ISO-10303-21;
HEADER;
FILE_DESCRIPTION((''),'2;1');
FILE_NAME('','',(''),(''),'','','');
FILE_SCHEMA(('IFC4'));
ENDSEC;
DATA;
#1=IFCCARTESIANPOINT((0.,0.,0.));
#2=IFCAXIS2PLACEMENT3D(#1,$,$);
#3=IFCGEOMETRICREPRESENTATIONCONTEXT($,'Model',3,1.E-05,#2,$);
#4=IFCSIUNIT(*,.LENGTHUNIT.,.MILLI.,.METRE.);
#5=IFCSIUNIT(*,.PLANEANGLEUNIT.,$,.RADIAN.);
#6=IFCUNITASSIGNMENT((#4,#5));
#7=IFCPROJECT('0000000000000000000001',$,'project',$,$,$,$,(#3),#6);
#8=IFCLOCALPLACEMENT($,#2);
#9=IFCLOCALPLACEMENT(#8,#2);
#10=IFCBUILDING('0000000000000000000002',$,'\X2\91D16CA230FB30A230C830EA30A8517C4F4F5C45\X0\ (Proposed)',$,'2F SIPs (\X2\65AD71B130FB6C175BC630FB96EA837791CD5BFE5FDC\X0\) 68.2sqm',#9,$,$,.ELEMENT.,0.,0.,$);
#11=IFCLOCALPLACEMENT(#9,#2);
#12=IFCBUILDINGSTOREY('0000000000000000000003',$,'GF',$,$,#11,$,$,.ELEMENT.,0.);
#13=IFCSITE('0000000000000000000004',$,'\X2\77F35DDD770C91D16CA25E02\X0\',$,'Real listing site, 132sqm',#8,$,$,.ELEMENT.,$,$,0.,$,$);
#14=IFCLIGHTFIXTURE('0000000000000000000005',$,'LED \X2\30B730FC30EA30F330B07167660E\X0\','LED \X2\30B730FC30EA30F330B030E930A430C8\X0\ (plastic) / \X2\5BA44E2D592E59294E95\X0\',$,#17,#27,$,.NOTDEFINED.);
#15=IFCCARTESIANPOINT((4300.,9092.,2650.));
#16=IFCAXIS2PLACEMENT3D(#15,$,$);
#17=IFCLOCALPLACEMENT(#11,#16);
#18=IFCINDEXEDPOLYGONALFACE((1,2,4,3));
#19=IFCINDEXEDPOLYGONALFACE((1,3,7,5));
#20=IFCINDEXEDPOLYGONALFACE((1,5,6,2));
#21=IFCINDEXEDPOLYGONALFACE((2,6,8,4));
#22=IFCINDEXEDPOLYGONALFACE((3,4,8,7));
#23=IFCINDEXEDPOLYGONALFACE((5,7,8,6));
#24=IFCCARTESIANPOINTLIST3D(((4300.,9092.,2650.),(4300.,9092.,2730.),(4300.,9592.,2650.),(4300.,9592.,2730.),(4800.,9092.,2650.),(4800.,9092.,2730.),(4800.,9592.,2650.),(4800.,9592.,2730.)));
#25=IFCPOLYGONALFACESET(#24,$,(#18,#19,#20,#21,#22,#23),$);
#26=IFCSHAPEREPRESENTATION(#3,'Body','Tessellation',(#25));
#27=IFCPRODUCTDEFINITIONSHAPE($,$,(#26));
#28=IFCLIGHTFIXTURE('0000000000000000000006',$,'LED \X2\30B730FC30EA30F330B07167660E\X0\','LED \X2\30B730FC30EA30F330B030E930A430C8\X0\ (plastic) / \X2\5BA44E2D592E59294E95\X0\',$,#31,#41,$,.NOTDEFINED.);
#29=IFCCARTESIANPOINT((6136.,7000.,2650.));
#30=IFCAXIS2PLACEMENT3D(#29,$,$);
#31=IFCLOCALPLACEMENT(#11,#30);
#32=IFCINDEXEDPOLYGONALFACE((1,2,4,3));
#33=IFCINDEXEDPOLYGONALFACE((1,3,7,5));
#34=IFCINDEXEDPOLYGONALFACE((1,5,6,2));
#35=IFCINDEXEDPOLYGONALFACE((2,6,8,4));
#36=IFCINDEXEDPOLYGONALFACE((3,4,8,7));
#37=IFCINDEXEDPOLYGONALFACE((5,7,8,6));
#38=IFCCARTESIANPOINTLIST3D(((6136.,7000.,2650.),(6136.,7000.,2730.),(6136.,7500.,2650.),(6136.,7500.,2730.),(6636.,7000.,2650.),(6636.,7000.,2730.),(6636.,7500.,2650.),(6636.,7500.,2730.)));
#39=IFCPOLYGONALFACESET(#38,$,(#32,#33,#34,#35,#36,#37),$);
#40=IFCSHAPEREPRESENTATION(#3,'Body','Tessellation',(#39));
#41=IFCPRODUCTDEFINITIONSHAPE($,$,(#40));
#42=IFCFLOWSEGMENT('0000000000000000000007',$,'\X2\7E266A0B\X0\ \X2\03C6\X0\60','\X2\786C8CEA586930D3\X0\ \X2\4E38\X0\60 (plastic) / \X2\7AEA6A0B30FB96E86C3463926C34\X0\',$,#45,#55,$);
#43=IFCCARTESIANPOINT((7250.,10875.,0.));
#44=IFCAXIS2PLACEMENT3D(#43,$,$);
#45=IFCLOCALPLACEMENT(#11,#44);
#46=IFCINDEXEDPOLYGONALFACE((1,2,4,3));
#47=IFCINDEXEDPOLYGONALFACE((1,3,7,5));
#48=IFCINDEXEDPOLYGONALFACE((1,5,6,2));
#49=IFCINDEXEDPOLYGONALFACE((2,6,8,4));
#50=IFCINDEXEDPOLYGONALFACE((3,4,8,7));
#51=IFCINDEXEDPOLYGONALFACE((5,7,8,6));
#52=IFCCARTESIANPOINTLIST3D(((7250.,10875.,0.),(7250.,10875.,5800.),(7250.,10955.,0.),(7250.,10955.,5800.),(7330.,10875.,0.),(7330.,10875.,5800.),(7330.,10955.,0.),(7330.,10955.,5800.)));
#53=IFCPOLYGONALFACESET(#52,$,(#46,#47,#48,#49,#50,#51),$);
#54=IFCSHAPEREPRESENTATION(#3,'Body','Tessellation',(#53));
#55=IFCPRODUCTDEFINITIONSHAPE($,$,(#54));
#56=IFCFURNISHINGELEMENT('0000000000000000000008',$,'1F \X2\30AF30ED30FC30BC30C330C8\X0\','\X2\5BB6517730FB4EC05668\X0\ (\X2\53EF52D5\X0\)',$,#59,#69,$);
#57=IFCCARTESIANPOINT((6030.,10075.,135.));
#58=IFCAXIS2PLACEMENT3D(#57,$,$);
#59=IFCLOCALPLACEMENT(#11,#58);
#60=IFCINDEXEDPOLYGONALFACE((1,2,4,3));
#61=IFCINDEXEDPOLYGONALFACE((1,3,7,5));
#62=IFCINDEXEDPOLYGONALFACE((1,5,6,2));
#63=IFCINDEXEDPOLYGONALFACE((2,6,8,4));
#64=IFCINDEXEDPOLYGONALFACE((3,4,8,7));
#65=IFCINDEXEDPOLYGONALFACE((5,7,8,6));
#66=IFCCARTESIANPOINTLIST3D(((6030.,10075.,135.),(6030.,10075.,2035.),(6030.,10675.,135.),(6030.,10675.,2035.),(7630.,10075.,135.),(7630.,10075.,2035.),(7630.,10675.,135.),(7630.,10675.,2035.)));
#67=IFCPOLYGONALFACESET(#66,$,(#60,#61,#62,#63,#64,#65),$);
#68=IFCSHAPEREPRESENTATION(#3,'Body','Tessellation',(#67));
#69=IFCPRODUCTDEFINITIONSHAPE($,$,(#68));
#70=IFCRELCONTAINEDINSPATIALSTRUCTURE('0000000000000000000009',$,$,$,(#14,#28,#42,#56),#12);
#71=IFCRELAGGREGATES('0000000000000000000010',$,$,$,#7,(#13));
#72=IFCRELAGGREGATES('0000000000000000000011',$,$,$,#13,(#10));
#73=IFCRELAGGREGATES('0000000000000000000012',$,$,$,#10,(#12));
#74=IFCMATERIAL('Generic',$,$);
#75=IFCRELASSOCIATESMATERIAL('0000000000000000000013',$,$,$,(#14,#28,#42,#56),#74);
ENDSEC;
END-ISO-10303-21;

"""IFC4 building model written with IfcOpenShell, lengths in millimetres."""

from ifc_helpers import new_model, si_unit, frame, frame_2d, origin, place, context, project, spatial, rectangle, extrude, material, element, save


model = new_model("IFC4")

# Units and contexts
model_context = context("Model", 3, precision=1e-05, world=origin())
ifc_project = project(units=[si_unit("LENGTHUNIT", "METRE", prefix="MILLI"), si_unit("PLANEANGLEUNIT", "RADIAN")], contexts=[model_context])

# Site, building, storey
site_placement = place(None, origin())
site = spatial("IfcSite", under=ifc_project, at=site_placement, Name="石川県金沢市", ObjectType="Real listing site, 132sqm", CompositionType="ELEMENT", RefElevation=0.0)
building_placement = place(site_placement, origin())
building = spatial("IfcBuilding", under=site, at=building_placement, Name="金沢・アトリエ兼住居 (Proposed)", ObjectType="2F SIPs (断熱・気密・雪荷重対応) 68.2sqm", CompositionType="ELEMENT", ElevationOfRefHeight=0.0, ElevationOfTerrain=0.0)
storey_placement = place(building_placement, origin())
storey = spatial("IfcBuildingStorey", under=building, at=storey_placement, Name="GF", CompositionType="ELEMENT", Elevation=0.0)

# Shared definitions
ifc_material_1 = material(Name="Generic")

# Light fixtures
light_fixture_1_placement = place(storey_placement, frame((4300.0, 9092.0, 2650.0)))
element("IfcLightFixture", 1, at=light_fixture_1_placement, inside=storey, material=ifc_material_1, Name="LED シーリング照明", Description="LED シーリングライト (plastic) / 室中央天井", PredefinedType="NOTDEFINED", context=model_context, shape_type="SweptSolid", body=[
    extrude(rectangle(XDim=500.0, YDim=500.0, at=frame_2d((250.0, 250.0))), frame((4300.0, 9092.0, 2650.0)), (0.0, 0.0, 1.0), 80.0),
])
light_fixture_2_placement = place(storey_placement, frame((6136.0, 7000.0, 2650.0)))
element("IfcLightFixture", 2, at=light_fixture_2_placement, inside=storey, material=ifc_material_1, Name="LED シーリング照明", Description="LED シーリングライト (plastic) / 室中央天井", PredefinedType="NOTDEFINED", context=model_context, shape_type="SweptSolid", body=[
    extrude(rectangle(XDim=500.0, YDim=500.0, at=frame_2d((250.0, 250.0))), frame((6136.0, 7000.0, 2650.0)), (0.0, 0.0, 1.0), 80.0),
])

# Flow segment
flow_segment_placement = place(storey_placement, frame((7250.0, 10875.0, 0.0)))
element("IfcFlowSegment", 3, at=flow_segment_placement, inside=storey, material=ifc_material_1, Name="縦樋 φ60", Description="硬質塩ビ 丸60 (plastic) / 竪樋・雨水排水", context=model_context, shape_type="SweptSolid", body=[
    extrude(rectangle(XDim=80.0, YDim=80.0, at=frame_2d((40.0, 40.0))), frame((7250.0, 10875.0, 0.0)), (0.0, 0.0, 1.0), 5800.0),
])

# Furnishing element
furnishing_placement = place(storey_placement, frame((6030.0, 10075.0, 135.0)))
element("IfcFurnishingElement", 4, at=furnishing_placement, inside=storey, material=ifc_material_1, Name="1F クローゼット", Description="家具・什器 (可動)", context=model_context, shape_type="SweptSolid", body=[
    extrude(rectangle(XDim=1600.0, YDim=600.0, at=frame_2d((800.0, 300.0))), frame((6030.0, 10075.0, 135.0)), (0.0, 0.0, 1.0), 1900.0),
])

save(model, "model.ifc")
